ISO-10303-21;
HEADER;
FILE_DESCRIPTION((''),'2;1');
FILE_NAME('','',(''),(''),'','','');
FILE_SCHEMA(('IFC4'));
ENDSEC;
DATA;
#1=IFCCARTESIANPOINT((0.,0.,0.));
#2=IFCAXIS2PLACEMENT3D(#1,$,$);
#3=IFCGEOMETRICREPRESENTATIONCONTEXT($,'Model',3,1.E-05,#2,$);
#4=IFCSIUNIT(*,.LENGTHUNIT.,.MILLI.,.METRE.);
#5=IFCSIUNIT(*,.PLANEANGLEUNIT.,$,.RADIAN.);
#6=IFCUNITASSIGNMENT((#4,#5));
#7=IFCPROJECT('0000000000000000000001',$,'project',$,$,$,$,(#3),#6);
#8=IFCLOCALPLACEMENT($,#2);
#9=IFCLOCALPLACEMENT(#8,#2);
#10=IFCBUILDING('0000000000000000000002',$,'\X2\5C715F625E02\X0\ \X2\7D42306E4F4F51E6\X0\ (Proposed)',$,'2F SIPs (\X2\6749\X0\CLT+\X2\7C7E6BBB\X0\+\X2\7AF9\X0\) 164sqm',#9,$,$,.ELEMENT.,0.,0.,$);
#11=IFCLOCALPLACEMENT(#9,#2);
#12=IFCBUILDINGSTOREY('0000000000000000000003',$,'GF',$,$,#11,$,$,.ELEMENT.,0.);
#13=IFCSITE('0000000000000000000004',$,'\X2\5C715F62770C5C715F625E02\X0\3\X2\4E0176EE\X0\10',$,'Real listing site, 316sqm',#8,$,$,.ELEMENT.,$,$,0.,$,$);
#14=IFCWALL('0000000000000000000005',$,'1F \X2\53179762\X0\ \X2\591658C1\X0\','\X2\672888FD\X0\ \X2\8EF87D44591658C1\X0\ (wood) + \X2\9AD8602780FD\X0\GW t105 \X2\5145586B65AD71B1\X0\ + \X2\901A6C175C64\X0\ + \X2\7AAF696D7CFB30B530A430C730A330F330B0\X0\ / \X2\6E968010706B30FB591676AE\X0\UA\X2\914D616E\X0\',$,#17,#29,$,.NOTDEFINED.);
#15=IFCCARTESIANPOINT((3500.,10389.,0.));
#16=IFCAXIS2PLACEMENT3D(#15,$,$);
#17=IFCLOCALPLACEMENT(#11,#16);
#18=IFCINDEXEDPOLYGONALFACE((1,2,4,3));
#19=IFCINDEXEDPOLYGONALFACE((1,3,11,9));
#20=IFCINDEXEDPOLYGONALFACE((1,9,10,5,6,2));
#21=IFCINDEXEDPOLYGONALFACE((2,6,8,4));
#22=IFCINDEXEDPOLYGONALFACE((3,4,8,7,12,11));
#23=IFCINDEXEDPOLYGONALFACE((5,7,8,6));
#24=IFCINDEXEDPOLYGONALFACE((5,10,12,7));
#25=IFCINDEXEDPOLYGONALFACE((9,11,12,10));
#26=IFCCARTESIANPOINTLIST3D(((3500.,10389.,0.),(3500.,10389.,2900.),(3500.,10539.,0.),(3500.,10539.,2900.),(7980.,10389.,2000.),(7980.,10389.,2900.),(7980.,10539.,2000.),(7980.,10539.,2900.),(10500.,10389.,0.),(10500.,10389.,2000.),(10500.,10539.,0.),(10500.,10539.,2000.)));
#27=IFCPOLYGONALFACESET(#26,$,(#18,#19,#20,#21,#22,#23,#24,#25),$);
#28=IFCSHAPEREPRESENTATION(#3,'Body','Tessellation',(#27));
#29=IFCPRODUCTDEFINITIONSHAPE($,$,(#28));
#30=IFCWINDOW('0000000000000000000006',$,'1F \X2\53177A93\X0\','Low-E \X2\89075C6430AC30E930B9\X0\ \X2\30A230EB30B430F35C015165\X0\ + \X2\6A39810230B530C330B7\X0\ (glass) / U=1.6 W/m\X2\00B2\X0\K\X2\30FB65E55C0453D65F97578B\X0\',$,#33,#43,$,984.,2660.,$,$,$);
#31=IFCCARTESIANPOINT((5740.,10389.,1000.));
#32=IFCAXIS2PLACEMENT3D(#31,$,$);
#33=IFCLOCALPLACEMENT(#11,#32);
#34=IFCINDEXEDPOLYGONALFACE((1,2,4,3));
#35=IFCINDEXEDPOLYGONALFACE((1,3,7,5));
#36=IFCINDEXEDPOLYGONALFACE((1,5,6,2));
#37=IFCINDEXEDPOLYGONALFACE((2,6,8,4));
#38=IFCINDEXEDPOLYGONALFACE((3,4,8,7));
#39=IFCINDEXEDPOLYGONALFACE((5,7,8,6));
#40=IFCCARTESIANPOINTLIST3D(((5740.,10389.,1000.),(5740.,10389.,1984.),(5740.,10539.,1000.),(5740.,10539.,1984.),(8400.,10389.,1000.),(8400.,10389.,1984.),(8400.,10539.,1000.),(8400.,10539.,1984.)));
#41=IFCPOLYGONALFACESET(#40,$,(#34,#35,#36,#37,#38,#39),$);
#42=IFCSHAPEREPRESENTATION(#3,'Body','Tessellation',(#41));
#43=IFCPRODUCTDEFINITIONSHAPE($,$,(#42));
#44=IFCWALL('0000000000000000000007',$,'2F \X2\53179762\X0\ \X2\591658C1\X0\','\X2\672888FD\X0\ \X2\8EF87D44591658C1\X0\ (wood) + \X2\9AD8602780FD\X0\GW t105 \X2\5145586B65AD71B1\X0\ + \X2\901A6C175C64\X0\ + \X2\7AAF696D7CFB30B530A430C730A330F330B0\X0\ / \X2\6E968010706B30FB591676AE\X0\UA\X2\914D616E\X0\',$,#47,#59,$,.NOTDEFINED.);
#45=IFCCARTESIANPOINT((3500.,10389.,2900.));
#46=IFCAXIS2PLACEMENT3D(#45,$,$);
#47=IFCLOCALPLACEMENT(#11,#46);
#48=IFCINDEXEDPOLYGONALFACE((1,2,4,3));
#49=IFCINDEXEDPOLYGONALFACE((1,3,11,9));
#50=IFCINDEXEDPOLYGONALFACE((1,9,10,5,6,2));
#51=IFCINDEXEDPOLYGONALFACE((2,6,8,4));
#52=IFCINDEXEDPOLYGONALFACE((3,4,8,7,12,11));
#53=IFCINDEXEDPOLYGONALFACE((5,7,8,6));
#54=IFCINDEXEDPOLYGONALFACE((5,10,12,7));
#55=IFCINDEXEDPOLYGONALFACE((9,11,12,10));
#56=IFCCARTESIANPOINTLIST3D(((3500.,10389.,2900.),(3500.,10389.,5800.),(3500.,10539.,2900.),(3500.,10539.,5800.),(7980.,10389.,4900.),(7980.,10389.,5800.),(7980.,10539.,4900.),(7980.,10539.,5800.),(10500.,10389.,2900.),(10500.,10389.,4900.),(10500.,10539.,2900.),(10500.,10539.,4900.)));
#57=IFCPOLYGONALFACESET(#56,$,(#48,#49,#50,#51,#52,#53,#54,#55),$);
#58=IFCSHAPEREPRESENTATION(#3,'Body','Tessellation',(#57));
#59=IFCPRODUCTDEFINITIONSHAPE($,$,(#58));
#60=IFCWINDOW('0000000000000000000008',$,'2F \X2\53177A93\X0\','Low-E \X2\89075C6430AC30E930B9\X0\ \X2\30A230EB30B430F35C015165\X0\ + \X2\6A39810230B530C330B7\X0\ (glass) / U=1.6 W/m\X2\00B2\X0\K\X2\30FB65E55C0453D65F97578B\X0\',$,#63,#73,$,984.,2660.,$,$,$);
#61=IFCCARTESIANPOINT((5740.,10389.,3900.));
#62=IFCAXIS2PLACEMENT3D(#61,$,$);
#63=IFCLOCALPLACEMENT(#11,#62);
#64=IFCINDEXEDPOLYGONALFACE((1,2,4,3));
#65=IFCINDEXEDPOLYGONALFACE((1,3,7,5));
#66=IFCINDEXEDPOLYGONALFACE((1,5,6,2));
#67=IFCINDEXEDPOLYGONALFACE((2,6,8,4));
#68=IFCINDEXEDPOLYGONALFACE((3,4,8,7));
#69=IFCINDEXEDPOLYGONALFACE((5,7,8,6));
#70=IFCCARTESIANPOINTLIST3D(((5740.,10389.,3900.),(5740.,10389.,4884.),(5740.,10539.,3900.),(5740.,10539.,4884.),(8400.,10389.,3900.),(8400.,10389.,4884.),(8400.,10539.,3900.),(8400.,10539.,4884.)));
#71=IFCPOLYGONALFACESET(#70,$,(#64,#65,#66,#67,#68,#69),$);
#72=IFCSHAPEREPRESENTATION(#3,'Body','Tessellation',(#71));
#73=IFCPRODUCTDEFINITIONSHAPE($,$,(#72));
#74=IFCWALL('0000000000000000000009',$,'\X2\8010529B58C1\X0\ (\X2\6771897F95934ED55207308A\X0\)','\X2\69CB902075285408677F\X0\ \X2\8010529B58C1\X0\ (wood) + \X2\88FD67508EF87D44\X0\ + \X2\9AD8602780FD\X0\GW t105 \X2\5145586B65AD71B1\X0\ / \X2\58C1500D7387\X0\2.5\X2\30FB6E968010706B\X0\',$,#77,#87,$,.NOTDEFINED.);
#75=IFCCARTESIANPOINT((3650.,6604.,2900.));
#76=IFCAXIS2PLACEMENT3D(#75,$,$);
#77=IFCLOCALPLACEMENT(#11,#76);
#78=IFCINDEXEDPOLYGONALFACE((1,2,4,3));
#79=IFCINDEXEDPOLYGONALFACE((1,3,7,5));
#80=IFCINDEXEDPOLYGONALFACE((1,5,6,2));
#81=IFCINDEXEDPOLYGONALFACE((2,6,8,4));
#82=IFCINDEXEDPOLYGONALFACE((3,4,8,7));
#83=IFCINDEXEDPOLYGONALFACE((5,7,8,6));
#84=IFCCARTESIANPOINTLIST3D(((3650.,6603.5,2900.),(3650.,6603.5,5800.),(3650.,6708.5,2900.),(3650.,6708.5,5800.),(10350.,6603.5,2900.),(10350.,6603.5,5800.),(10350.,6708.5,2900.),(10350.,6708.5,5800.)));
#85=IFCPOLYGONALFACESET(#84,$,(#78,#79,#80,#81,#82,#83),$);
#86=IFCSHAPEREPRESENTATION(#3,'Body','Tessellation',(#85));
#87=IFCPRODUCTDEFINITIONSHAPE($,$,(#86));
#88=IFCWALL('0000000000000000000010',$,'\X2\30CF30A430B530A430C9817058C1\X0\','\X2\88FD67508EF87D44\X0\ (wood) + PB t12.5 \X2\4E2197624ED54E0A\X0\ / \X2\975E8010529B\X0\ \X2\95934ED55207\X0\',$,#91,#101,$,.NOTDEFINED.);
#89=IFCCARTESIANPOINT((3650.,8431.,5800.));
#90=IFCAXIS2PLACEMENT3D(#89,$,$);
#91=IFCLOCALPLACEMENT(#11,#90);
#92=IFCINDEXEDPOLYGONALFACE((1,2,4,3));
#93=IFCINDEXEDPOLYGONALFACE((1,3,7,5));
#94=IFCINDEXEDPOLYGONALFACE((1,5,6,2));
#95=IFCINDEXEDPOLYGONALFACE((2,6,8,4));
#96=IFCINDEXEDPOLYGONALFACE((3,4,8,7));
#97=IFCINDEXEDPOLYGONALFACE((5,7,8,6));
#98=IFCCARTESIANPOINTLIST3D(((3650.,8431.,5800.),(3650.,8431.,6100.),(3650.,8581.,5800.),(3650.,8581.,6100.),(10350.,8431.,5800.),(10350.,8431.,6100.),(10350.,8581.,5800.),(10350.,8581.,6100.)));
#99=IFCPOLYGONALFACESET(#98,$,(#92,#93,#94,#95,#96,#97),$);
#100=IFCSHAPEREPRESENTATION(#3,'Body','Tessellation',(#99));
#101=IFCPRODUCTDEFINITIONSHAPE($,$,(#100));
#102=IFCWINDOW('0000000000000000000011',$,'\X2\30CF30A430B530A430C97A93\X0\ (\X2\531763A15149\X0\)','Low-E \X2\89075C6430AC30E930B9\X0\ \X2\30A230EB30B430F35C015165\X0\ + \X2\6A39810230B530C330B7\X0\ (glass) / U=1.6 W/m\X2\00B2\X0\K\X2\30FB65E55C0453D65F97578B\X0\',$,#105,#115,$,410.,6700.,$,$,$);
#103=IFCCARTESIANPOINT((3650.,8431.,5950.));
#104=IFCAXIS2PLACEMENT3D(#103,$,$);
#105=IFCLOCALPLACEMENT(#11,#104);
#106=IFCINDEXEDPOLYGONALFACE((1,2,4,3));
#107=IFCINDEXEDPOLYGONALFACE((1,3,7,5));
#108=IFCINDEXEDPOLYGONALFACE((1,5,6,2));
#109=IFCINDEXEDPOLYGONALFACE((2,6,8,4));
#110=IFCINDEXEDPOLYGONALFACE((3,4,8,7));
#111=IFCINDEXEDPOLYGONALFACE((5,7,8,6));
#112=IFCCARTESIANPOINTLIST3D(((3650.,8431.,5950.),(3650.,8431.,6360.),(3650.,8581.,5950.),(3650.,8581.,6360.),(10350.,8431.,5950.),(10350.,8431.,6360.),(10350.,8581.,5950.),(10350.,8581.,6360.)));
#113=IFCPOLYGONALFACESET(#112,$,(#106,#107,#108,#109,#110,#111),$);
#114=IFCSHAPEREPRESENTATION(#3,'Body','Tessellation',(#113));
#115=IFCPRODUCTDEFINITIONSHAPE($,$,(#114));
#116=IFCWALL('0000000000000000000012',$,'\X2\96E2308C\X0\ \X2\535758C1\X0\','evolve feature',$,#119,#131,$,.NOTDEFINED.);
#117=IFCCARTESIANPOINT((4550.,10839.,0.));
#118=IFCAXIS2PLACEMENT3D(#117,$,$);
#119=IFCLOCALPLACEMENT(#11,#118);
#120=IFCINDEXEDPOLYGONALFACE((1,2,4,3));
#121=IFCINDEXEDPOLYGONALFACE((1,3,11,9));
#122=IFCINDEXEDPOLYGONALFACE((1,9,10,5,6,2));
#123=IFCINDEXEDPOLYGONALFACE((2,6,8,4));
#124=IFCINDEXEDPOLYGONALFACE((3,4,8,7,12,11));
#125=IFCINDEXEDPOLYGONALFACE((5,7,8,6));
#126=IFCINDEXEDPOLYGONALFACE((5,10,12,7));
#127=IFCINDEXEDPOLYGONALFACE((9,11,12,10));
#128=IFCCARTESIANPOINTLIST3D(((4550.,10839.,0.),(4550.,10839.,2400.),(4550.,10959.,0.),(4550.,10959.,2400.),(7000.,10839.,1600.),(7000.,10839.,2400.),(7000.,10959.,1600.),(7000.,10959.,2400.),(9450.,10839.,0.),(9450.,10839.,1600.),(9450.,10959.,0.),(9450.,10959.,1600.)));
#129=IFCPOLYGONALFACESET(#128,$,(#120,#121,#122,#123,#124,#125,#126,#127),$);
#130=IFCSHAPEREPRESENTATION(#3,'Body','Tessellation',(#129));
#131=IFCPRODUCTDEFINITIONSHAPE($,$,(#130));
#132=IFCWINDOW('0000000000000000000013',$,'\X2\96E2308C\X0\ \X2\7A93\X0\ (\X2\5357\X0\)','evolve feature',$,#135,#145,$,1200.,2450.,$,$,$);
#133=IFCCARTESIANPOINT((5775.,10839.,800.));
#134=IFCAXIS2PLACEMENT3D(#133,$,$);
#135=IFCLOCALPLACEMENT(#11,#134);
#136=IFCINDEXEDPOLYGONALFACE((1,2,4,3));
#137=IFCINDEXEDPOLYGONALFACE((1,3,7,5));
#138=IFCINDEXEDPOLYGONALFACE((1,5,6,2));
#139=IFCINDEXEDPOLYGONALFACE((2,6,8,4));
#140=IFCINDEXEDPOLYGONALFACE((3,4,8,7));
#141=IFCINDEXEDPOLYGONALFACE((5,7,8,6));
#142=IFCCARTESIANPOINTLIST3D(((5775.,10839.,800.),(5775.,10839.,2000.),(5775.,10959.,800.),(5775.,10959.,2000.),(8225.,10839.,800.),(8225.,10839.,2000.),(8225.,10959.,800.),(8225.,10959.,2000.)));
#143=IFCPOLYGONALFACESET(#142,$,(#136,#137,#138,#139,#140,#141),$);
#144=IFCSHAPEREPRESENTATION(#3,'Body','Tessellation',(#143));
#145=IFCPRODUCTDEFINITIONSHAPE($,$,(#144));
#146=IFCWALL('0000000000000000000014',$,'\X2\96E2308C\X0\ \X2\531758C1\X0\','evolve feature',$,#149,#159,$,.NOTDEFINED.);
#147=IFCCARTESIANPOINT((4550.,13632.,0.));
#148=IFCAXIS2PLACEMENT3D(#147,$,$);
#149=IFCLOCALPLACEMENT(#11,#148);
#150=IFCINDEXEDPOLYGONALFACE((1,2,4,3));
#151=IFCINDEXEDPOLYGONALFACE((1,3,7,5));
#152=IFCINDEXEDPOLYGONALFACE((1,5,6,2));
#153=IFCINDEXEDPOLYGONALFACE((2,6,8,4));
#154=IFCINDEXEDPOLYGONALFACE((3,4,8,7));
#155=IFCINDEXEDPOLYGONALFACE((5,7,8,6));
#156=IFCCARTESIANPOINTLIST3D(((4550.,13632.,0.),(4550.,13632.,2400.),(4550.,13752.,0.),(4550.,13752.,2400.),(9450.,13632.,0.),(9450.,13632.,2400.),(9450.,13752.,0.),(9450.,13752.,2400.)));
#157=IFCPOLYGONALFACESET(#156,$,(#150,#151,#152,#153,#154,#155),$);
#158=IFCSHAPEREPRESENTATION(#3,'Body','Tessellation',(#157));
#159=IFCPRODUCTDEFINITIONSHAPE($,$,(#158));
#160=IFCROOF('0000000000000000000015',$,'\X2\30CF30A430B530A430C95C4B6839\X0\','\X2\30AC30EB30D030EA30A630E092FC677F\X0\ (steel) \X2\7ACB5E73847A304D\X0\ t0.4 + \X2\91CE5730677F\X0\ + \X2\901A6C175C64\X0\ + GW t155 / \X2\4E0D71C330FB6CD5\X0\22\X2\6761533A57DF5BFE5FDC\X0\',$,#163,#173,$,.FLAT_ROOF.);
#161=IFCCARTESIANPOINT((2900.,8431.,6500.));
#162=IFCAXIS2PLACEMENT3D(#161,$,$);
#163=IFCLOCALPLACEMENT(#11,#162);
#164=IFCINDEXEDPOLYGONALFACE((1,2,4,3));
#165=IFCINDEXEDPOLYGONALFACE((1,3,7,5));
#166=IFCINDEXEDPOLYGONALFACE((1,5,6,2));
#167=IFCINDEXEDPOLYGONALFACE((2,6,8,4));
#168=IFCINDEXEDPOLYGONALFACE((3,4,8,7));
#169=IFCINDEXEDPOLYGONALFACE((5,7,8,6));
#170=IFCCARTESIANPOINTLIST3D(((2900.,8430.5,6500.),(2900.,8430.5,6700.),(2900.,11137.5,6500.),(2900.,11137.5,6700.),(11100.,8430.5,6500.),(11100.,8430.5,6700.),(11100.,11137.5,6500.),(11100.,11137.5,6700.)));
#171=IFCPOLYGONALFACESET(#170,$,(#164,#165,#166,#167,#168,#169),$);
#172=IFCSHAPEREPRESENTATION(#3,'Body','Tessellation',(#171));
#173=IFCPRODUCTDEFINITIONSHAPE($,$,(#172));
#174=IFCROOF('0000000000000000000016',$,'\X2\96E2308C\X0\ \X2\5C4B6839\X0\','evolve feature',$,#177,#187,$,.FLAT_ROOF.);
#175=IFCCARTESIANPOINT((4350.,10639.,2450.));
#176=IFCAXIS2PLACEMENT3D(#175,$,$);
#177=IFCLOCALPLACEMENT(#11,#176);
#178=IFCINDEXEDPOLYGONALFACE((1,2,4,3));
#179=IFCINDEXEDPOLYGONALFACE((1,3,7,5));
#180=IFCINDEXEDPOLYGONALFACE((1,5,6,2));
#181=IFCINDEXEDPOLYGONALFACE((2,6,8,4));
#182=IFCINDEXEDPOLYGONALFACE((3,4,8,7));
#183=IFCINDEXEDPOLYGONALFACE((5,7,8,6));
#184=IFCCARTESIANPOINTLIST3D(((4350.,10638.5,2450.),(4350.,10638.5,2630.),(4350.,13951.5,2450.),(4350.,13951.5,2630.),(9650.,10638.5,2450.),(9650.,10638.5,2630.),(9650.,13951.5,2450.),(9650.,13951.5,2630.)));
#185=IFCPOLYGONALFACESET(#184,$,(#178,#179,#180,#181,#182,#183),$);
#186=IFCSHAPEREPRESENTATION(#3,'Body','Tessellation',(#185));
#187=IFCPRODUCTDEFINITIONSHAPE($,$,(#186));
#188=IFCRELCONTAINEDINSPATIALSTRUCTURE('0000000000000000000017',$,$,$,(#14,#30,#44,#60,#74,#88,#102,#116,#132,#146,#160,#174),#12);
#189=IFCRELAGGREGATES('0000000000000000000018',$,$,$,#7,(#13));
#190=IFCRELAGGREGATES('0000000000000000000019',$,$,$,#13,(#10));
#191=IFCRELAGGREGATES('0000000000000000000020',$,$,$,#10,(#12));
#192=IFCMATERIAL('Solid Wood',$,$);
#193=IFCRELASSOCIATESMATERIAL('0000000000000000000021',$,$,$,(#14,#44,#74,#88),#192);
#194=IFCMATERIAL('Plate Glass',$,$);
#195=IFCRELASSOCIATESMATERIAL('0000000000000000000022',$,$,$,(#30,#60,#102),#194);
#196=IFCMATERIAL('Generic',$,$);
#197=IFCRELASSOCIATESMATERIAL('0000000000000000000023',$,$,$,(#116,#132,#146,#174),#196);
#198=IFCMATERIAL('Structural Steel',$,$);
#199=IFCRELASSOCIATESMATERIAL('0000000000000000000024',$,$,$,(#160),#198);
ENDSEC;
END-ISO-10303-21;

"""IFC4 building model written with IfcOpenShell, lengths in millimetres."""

from ifc_helpers import new_model, si_unit, frame, frame_2d, origin, place, context, project, spatial, rectangle, extrude, material, element, fill, save


model = new_model("IFC4")

# Units and contexts
model_context = context("Model", 3, precision=1e-05, world=origin())
ifc_project = project(units=[si_unit("LENGTHUNIT", "METRE", prefix="MILLI"), si_unit("PLANEANGLEUNIT", "RADIAN")], contexts=[model_context])

# Site, building, storey
site_placement = place(None, origin())
site = spatial("IfcSite", under=ifc_project, at=site_placement, Name="山形県山形市3丁目10", ObjectType="Real listing site, 316sqm", CompositionType="ELEMENT", RefElevation=0.0)
building_placement = place(site_placement, origin())
building = spatial("IfcBuilding", under=site, at=building_placement, Name="山形市 終の住処 (Proposed)", ObjectType="2F SIPs (杉CLT+籾殻+竹) 164sqm", CompositionType="ELEMENT", ElevationOfRefHeight=0.0, ElevationOfTerrain=0.0)
storey_placement = place(building_placement, origin())
storey = spatial("IfcBuildingStorey", under=building, at=storey_placement, Name="GF", CompositionType="ELEMENT", Elevation=0.0)

# Shared definitions
ifc_material_1 = material(Name="Generic")

# Wall, opening, window
ifc_material_2 = material(Name="Solid Wood")
wall_1_placement = place(storey_placement, frame((3500.0, 10389.0, 0.0)))
wall_1 = element("IfcWall", 1, at=wall_1_placement, inside=storey, material=ifc_material_2, Name="1F 北面 外壁", Description="木製 軸組外壁 (wood) + 高性能GW t105 充填断熱 + 通気層 + 窯業系サイディング / 準耐火・外皮UA配慮", PredefinedType="NOTDEFINED", context=model_context, shape_type="SweptSolid", body=[
    extrude(rectangle(XDim=7000.0, YDim=150.0, at=frame_2d((3500.0, 75.0))), frame((3500.0, 10389.0, 0.0)), (0.0, 0.0, 1.0), 2900.0),
])
opening_1_placement = place(storey_placement, frame((5740.0, 10389.0, 1000.0)))
opening_1 = element("IfcOpeningElement", 2, at=opening_1_placement, cuts=wall_1, PredefinedType="NOTDEFINED", context=model_context, shape_type="SweptSolid", body=[
    extrude(rectangle(XDim=2660.0, YDim=150.0, at=frame_2d((1330.0, 75.0))), frame((5740.0, 10389.0, 1000.0)), (0.0, 0.0, 1.0), 984.0),
])
ifc_material_3 = material(Name="Plate Glass")
window_1_placement = place(storey_placement, frame((5740.0, 10389.0, 1000.0)))
window_1 = element("IfcWindow", 3, at=window_1_placement, inside=storey, material=ifc_material_3, Name="1F 北窓", Description="Low-E 複層ガラス アルゴン封入 + 樹脂サッシ (glass) / U=1.6 W/m²K・日射取得型", OverallHeight=984.0, OverallWidth=2660.0, context=model_context, shape_type="SweptSolid", body=[
    extrude(rectangle(XDim=2660.0, YDim=150.0, at=frame_2d((1330.0, 75.0))), frame((5740.0, 10389.0, 1000.0)), (0.0, 0.0, 1.0), 984.0),
])
fill(opening_1, window_1)

# Wall, opening, window
wall_2_placement = place(storey_placement, frame((3500.0, 10389.0, 2900.0)))
wall_2 = element("IfcWall", 4, at=wall_2_placement, inside=storey, material=ifc_material_2, Name="2F 北面 外壁", Description="木製 軸組外壁 (wood) + 高性能GW t105 充填断熱 + 通気層 + 窯業系サイディング / 準耐火・外皮UA配慮", PredefinedType="NOTDEFINED", context=model_context, shape_type="SweptSolid", body=[
    extrude(rectangle(XDim=7000.0, YDim=150.0, at=frame_2d((3500.0, 75.0))), frame((3500.0, 10389.0, 2900.0)), (0.0, 0.0, 1.0), 2900.0),
])
opening_2_placement = place(storey_placement, frame((5740.0, 10389.0, 3900.0)))
opening_2 = element("IfcOpeningElement", 5, at=opening_2_placement, cuts=wall_2, PredefinedType="NOTDEFINED", context=model_context, shape_type="SweptSolid", body=[
    extrude(rectangle(XDim=2660.0, YDim=150.0, at=frame_2d((1330.0, 75.0))), frame((5740.0, 10389.0, 3900.0)), (0.0, 0.0, 1.0), 984.0),
])
window_2_placement = place(storey_placement, frame((5740.0, 10389.0, 3900.0)))
window_2 = element("IfcWindow", 6, at=window_2_placement, inside=storey, material=ifc_material_3, Name="2F 北窓", Description="Low-E 複層ガラス アルゴン封入 + 樹脂サッシ (glass) / U=1.6 W/m²K・日射取得型", OverallHeight=984.0, OverallWidth=2660.0, context=model_context, shape_type="SweptSolid", body=[
    extrude(rectangle(XDim=2660.0, YDim=150.0, at=frame_2d((1330.0, 75.0))), frame((5740.0, 10389.0, 3900.0)), (0.0, 0.0, 1.0), 984.0),
])
fill(opening_2, window_2)

# Wall
wall_3_placement = place(storey_placement, frame((3650.0, 6604.0, 2900.0)))
element("IfcWall", 7, at=wall_3_placement, inside=storey, material=ifc_material_2, Name="耐力壁 (東西間仕切り)", Description="構造用合板 耐力壁 (wood) + 製材軸組 + 高性能GW t105 充填断熱 / 壁倍率2.5・準耐火", PredefinedType="NOTDEFINED", context=model_context, shape_type="SweptSolid", body=[
    extrude(rectangle(XDim=6700.0, YDim=105.0, at=frame_2d((3350.0, 52.0))), frame((3650.0, 6604.0, 2900.0)), (0.0, 0.0, 1.0), 2900.0),
])

# Walls, openings, windows
wall_4_placement = place(storey_placement, frame((3650.0, 8431.0, 5800.0)))
wall_4 = element("IfcWall", 8, at=wall_4_placement, inside=storey, material=ifc_material_2, Name="ハイサイド腰壁", Description="製材軸組 (wood) + PB t12.5 両面仕上 / 非耐力 間仕切", PredefinedType="NOTDEFINED", context=model_context, shape_type="SweptSolid", body=[
    extrude(rectangle(XDim=6700.0, YDim=150.0, at=frame_2d((3350.0, 75.0))), frame((3650.0, 8431.0, 5800.0)), (0.0, 0.0, 1.0), 700.0),
])
opening_3_placement = place(storey_placement, frame((3650.0, 8431.0, 5950.0)))
opening_3 = element("IfcOpeningElement", 9, at=opening_3_placement, cuts=wall_4, PredefinedType="NOTDEFINED", context=model_context, shape_type="SweptSolid", body=[
    extrude(rectangle(XDim=6700.0, YDim=150.0, at=frame_2d((3350.0, 75.0))), frame((3650.0, 8431.0, 5950.0)), (0.0, 0.0, 1.0), 410.0),
])
window_3_placement = place(storey_placement, frame((3650.0, 8431.0, 5950.0)))
window_3 = element("IfcWindow", 10, at=window_3_placement, inside=storey, material=ifc_material_3, Name="ハイサイド窓 (北採光)", Description="Low-E 複層ガラス アルゴン封入 + 樹脂サッシ (glass) / U=1.6 W/m²K・日射取得型", OverallHeight=410.0, OverallWidth=6700.0, context=model_context, shape_type="SweptSolid", body=[
    extrude(rectangle(XDim=6700.0, YDim=150.0, at=frame_2d((3350.0, 75.0))), frame((3650.0, 8431.0, 5950.0)), (0.0, 0.0, 1.0), 410.0),
])
fill(opening_3, window_3)
wall_5_placement = place(storey_placement, frame((4550.0, 10839.0, 0.0)))
wall_5 = element("IfcWall", 11, at=wall_5_placement, inside=storey, material=ifc_material_1, Name="離れ 南壁", Description="evolve feature", PredefinedType="NOTDEFINED", context=model_context, shape_type="SweptSolid", body=[
    extrude(rectangle(XDim=4900.0, YDim=120.0, at=frame_2d((2450.0, 60.0))), frame((4550.0, 10839.0, 0.0)), (0.0, 0.0, 1.0), 2400.0),
])
opening_4_placement = place(storey_placement, frame((5775.0, 10839.0, 800.0)))
opening_4 = element("IfcOpeningElement", 12, at=opening_4_placement, cuts=wall_5, PredefinedType="NOTDEFINED", context=model_context, shape_type="SweptSolid", body=[
    extrude(rectangle(XDim=2450.0, YDim=120.0, at=frame_2d((1225.0, 60.0))), frame((5775.0, 10839.0, 800.0)), (0.0, 0.0, 1.0), 1200.0),
])
window_4_placement = place(storey_placement, frame((5775.0, 10839.0, 800.0)))
window_4 = element("IfcWindow", 13, at=window_4_placement, inside=storey, material=ifc_material_1, Name="離れ 窓 (南)", Description="evolve feature", OverallHeight=1200.0, OverallWidth=2450.0, context=model_context, shape_type="SweptSolid", body=[
    extrude(rectangle(XDim=2450.0, YDim=120.0, at=frame_2d((1225.0, 60.0))), frame((5775.0, 10839.0, 800.0)), (0.0, 0.0, 1.0), 1200.0),
])
fill(opening_4, window_4)

# Wall
wall_6_placement = place(storey_placement, frame((4550.0, 13632.0, 0.0)))
element("IfcWall", 14, at=wall_6_placement, inside=storey, material=ifc_material_1, Name="離れ 北壁", Description="evolve feature", PredefinedType="NOTDEFINED", context=model_context, shape_type="SweptSolid", body=[
    extrude(rectangle(XDim=4900.0, YDim=120.0, at=frame_2d((2450.0, 60.0))), frame((4550.0, 13632.0, 0.0)), (0.0, 0.0, 1.0), 2400.0),
])

# Roofs
ifc_material_4 = material(Name="Structural Steel")
roof_1_placement = place(storey_placement, frame((2900.0, 8431.0, 6500.0)))
element("IfcRoof", 15, at=roof_1_placement, inside=storey, material=ifc_material_4, Name="ハイサイド屋根", Description="ガルバリウム鋼板 (steel) 立平葺き t0.4 + 野地板 + 通気層 + GW t155 / 不燃・法22条区域対応", PredefinedType="FLAT_ROOF", context=model_context, shape_type="SweptSolid", body=[
    extrude(rectangle(XDim=8200.0, YDim=2707.0, at=frame_2d((4100.0, 1353.0))), frame((2900.0, 8431.0, 6500.0)), (0.0, 0.0, 1.0), 200.0),
])
roof_2_placement = place(storey_placement, frame((4350.0, 10639.0, 2450.0)))
element("IfcRoof", 16, at=roof_2_placement, inside=storey, material=ifc_material_1, Name="離れ 屋根", Description="evolve feature", PredefinedType="FLAT_ROOF", context=model_context, shape_type="SweptSolid", body=[
    extrude(rectangle(XDim=5300.0, YDim=3313.0, at=frame_2d((2650.0, 1656.0))), frame((4350.0, 10639.0, 2450.0)), (0.0, 0.0, 1.0), 180.0),
])

save(model, "model.ifc")
